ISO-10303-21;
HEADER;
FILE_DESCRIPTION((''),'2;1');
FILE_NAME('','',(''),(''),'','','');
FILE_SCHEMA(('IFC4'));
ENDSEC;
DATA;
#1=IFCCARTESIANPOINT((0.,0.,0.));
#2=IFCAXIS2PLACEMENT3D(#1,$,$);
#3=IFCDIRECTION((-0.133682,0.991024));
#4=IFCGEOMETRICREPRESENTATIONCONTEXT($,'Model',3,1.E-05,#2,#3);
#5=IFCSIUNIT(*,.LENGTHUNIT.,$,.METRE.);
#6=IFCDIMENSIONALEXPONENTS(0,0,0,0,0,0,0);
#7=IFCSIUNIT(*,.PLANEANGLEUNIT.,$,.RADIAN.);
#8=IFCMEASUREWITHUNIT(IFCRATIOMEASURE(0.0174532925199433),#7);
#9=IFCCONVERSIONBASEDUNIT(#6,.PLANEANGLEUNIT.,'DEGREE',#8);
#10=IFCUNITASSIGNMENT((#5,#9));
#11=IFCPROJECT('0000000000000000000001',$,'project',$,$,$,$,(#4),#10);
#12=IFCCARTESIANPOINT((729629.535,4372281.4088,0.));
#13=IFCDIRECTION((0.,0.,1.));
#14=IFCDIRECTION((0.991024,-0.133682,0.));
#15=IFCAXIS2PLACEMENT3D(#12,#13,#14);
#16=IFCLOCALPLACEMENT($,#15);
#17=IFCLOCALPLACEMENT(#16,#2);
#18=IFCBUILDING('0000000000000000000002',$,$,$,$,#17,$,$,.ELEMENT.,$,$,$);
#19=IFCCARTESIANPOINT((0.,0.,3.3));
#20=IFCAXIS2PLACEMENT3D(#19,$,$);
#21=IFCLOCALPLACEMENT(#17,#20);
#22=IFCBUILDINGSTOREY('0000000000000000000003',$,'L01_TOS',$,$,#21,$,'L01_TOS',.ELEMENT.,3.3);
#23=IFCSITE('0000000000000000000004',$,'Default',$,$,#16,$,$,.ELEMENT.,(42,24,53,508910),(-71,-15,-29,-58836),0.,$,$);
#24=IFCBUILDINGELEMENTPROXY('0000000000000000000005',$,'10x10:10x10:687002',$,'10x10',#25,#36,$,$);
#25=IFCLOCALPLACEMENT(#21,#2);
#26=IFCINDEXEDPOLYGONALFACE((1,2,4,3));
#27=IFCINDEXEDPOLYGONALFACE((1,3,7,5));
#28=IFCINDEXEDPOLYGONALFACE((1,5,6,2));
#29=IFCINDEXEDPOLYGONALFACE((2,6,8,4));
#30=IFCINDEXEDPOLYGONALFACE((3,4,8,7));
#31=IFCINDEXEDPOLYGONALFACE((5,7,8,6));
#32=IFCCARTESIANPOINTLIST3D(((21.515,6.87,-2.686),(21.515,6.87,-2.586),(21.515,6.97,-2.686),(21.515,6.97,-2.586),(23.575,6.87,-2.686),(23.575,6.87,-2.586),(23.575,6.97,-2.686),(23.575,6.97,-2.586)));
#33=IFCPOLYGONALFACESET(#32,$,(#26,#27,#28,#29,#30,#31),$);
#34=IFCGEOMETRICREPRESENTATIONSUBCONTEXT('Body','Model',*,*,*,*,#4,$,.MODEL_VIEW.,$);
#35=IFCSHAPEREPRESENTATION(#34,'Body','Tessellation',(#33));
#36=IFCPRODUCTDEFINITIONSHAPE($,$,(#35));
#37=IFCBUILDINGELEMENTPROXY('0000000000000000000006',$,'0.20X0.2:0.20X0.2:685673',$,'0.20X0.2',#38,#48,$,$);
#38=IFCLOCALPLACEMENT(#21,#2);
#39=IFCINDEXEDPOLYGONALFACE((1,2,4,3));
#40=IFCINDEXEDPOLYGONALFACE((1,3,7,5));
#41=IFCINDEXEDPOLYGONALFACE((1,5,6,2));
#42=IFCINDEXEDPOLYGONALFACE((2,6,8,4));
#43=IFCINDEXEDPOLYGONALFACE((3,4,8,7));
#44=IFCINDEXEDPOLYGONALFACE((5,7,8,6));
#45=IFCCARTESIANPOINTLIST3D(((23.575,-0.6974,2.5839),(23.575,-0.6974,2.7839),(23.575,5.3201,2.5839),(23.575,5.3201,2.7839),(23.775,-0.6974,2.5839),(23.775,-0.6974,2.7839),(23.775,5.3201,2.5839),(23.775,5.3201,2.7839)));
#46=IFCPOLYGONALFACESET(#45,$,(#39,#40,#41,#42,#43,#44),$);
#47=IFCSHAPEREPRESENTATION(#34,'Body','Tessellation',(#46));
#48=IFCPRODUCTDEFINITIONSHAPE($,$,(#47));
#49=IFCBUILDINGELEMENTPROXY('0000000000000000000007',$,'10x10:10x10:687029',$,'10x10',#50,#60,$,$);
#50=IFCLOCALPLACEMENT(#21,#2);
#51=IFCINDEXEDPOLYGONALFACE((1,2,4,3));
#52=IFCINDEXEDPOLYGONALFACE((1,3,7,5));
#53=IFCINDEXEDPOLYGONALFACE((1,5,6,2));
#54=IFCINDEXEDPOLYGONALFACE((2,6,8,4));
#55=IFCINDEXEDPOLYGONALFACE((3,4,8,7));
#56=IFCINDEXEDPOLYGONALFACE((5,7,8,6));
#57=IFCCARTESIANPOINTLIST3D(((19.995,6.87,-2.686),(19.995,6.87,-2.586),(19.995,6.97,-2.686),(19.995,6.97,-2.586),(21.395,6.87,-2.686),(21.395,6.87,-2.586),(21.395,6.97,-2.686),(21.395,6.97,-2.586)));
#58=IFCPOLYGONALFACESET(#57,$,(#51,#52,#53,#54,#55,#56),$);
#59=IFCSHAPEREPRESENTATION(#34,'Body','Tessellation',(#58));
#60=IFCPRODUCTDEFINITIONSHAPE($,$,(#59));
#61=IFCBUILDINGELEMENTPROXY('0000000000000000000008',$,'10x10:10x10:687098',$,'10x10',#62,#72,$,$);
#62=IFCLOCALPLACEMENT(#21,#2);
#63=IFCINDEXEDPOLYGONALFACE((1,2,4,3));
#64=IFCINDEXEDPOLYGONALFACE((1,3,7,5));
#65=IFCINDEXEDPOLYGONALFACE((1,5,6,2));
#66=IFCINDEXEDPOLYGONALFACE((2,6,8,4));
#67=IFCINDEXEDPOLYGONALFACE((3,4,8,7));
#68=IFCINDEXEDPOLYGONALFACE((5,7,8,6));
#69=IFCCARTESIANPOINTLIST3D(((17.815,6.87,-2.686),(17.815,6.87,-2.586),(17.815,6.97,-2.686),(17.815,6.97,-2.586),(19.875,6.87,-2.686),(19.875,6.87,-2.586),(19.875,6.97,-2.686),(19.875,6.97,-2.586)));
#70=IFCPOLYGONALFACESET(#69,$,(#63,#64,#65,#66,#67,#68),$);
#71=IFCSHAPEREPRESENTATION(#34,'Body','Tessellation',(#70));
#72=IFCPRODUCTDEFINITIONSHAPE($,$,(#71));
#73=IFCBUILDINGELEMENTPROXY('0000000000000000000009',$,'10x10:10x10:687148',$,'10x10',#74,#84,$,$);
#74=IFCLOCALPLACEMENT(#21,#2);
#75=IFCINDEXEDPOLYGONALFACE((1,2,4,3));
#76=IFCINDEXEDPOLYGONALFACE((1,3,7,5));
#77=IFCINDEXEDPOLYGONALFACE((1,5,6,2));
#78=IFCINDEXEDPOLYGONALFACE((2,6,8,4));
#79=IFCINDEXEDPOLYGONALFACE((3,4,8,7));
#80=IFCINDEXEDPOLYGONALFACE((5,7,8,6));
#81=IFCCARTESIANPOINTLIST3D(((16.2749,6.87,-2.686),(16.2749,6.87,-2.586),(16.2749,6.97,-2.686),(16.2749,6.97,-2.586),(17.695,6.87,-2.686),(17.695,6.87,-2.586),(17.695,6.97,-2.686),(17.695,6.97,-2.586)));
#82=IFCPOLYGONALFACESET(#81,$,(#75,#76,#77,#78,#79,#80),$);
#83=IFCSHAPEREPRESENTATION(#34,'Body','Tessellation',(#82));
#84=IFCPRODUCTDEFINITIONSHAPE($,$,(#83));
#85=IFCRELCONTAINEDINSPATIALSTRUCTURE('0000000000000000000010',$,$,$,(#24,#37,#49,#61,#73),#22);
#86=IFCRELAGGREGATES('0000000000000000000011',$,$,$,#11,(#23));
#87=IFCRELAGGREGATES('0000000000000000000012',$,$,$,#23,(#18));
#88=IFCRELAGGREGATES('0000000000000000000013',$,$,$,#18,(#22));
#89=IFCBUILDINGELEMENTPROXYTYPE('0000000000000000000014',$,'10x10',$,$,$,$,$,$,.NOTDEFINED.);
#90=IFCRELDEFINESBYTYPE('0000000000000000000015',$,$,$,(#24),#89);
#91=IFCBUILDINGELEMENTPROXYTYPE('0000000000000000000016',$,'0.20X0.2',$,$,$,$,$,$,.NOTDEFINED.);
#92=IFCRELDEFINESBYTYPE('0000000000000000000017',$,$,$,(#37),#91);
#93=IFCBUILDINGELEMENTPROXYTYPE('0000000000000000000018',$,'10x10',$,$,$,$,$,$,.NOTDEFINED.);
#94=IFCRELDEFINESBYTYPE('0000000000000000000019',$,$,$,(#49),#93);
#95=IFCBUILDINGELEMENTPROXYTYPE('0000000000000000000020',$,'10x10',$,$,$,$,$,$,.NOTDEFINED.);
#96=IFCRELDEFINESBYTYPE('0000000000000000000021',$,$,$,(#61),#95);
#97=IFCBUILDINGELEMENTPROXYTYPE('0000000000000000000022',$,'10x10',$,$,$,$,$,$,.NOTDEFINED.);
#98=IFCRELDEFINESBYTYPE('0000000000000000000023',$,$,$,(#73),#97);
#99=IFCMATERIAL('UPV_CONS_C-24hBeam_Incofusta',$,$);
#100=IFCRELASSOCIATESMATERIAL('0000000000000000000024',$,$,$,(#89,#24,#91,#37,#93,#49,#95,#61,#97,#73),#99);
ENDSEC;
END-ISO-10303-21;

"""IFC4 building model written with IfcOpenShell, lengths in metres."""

from ifc_helpers import new_model, entity, si_unit, converted_unit, direction, frame, frame_2d, origin, origin_2d_with_axis, place, context, subcontext, project, spatial, rectangle, extrude, source, transform, mapped, material, type_object, type_shapes, element, save


model = new_model("IFC4")

# Units and contexts
model_context = context("Model", 3, precision=1e-05, world=origin(), true_north=direction((-0.133682, 0.991024)))
body_context = subcontext(model_context, "Body", "Model", "MODEL_VIEW")
ifc_project = project(units=[si_unit("LENGTHUNIT", "METRE"), converted_unit("PLANEANGLEUNIT", "DEGREE", entity("IfcRatioMeasure", 0.0174532925199433), si_unit("PLANEANGLEUNIT", "RADIAN"), dimensions=[0, 0, 0, 0, 0, 0, 0])], contexts=[model_context])

# Site, building, storey
site_placement = place(None, frame((729629.535, 4372281.4088, 0.0), z_axis=(0.0, 0.0, 1.0), x_axis=(0.991024, -0.133682, 0.0)))
site = spatial("IfcSite", under=ifc_project, at=site_placement, Name="Default", CompositionType="ELEMENT", RefLatitude=(42, 24, 53, 508910), RefLongitude=(-71, -15, -29, -58836), RefElevation=0.0)
building_placement = place(site_placement, origin())
building = spatial("IfcBuilding", under=site, at=building_placement, CompositionType="ELEMENT")
storey_placement = place(building_placement, frame((0.0, 0.0, 3.3)))
storey = spatial("IfcBuildingStorey", under=building, at=storey_placement, Name="L01_TOS", LongName="L01_TOS", CompositionType="ELEMENT", Elevation=3.3)

# Building element proxies
ifc_material = material(Name="UPV_CONS_C-24hBeam_Incofusta")
building_element_proxy_type_1 = type_object("IfcBuildingElementProxyType", Name="10x10", material=ifc_material)
shared_shape_1 = source(origin(), body_context, "Body", "SweptSolid", [
    extrude(rectangle(XDim=0.1, YDim=2.06, at=frame_2d((0.0, 0.0), x_axis=(1.0, 0.0))), frame((1.03, 0.05, 0.0), z_axis=(0.0, 0.0, 1.0), x_axis=(0.0, -1.0, 0.0)), (0.0, 0.0, 1.0), 0.1),
])
type_shapes(building_element_proxy_type_1, [shared_shape_1])
proxy_1_placement = place(storey_placement, frame((21.515, 6.87, -2.686)))
element("IfcBuildingElementProxy", 1, at=proxy_1_placement, inside=storey, type_object=building_element_proxy_type_1, material=ifc_material, Name="10x10:10x10:687002", ObjectType="10x10", context=body_context, shape_type="MappedRepresentation", body=[
    mapped(shared_shape_1, transform((0.0, 0.0, 0.0), scale=1.0)),
])
building_element_proxy_type_2 = type_object("IfcBuildingElementProxyType", Name="0.20X0.2", material=ifc_material)
shared_shape_2 = source(origin(), body_context, "Body", "SweptSolid", [
    extrude(rectangle(XDim=0.2, YDim=6.0175, at=origin_2d_with_axis()), frame((0.3898, 0.0, -0.0999), z_axis=(0.0, 0.0, 1.0), x_axis=(0.0, -1.0, 0.0)), (0.0, 0.0, 1.0), 0.2),
])
type_shapes(building_element_proxy_type_2, [shared_shape_2])
proxy_2_placement = place(storey_placement, frame((23.675, 1.9216, 2.6838), z_axis=(0.0, 0.0, 1.0), x_axis=(0.0, 1.0, 0.0)))
element("IfcBuildingElementProxy", 2, at=proxy_2_placement, inside=storey, type_object=building_element_proxy_type_2, material=ifc_material, Name="0.20X0.2:0.20X0.2:685673", ObjectType="0.20X0.2", context=body_context, shape_type="MappedRepresentation", body=[
    mapped(shared_shape_2, transform((0.0, 0.0, 0.0), scale=1.0)),
])
building_element_proxy_type_3 = type_object("IfcBuildingElementProxyType", Name="10x10", material=ifc_material)
shared_shape_3 = source(origin(), body_context, "Body", "SweptSolid", [
    extrude(rectangle(XDim=0.1, YDim=1.4, at=frame_2d((0.0, 0.0), x_axis=(1.0, 0.0))), frame((0.7, 0.05, 0.0), z_axis=(0.0, 0.0, 1.0), x_axis=(0.0, -1.0, 0.0)), (0.0, 0.0, 1.0), 0.1),
])
type_shapes(building_element_proxy_type_3, [shared_shape_3])
proxy_3_placement = place(storey_placement, frame((19.995, 6.87, -2.686)))
element("IfcBuildingElementProxy", 3, at=proxy_3_placement, inside=storey, type_object=building_element_proxy_type_3, material=ifc_material, Name="10x10:10x10:687029", ObjectType="10x10", context=body_context, shape_type="MappedRepresentation", body=[
    mapped(shared_shape_3, transform((0.0, 0.0, 0.0), scale=1.0)),
])
building_element_proxy_type_4 = type_object("IfcBuildingElementProxyType", Name="10x10", material=ifc_material)
shared_shape_4 = source(origin(), body_context, "Body", "SweptSolid", [
    extrude(rectangle(XDim=0.1, YDim=2.06, at=origin_2d_with_axis()), frame((1.03, 0.05, 0.0), z_axis=(0.0, 0.0, 1.0), x_axis=(0.0, -1.0, 0.0)), (0.0, 0.0, 1.0), 0.1),
])
type_shapes(building_element_proxy_type_4, [shared_shape_4])
proxy_4_placement = place(storey_placement, frame((17.815, 6.87, -2.686)))
element("IfcBuildingElementProxy", 4, at=proxy_4_placement, inside=storey, type_object=building_element_proxy_type_4, material=ifc_material, Name="10x10:10x10:687098", ObjectType="10x10", context=body_context, shape_type="MappedRepresentation", body=[
    mapped(shared_shape_4, transform((0.0, 0.0, 0.0), scale=1.0)),
])
building_element_proxy_type_5 = type_object("IfcBuildingElementProxyType", Name="10x10", material=ifc_material)
shared_shape_5 = source(origin(), body_context, "Body", "SweptSolid", [
    extrude(rectangle(XDim=0.1, YDim=1.4201, at=origin_2d_with_axis()), frame((0.7101, 0.05, 0.0), z_axis=(0.0, 0.0, 1.0), x_axis=(0.0, -1.0, 0.0)), (0.0, 0.0, 1.0), 0.1),
])
type_shapes(building_element_proxy_type_5, [shared_shape_5])
proxy_5_placement = place(storey_placement, frame((16.2749, 6.87, -2.686)))
element("IfcBuildingElementProxy", 5, at=proxy_5_placement, inside=storey, type_object=building_element_proxy_type_5, material=ifc_material, Name="10x10:10x10:687148", ObjectType="10x10", context=body_context, shape_type="MappedRepresentation", body=[
    mapped(shared_shape_5, transform((0.0, 0.0, 0.0), scale=1.0)),
])

save(model, "model.ifc")
